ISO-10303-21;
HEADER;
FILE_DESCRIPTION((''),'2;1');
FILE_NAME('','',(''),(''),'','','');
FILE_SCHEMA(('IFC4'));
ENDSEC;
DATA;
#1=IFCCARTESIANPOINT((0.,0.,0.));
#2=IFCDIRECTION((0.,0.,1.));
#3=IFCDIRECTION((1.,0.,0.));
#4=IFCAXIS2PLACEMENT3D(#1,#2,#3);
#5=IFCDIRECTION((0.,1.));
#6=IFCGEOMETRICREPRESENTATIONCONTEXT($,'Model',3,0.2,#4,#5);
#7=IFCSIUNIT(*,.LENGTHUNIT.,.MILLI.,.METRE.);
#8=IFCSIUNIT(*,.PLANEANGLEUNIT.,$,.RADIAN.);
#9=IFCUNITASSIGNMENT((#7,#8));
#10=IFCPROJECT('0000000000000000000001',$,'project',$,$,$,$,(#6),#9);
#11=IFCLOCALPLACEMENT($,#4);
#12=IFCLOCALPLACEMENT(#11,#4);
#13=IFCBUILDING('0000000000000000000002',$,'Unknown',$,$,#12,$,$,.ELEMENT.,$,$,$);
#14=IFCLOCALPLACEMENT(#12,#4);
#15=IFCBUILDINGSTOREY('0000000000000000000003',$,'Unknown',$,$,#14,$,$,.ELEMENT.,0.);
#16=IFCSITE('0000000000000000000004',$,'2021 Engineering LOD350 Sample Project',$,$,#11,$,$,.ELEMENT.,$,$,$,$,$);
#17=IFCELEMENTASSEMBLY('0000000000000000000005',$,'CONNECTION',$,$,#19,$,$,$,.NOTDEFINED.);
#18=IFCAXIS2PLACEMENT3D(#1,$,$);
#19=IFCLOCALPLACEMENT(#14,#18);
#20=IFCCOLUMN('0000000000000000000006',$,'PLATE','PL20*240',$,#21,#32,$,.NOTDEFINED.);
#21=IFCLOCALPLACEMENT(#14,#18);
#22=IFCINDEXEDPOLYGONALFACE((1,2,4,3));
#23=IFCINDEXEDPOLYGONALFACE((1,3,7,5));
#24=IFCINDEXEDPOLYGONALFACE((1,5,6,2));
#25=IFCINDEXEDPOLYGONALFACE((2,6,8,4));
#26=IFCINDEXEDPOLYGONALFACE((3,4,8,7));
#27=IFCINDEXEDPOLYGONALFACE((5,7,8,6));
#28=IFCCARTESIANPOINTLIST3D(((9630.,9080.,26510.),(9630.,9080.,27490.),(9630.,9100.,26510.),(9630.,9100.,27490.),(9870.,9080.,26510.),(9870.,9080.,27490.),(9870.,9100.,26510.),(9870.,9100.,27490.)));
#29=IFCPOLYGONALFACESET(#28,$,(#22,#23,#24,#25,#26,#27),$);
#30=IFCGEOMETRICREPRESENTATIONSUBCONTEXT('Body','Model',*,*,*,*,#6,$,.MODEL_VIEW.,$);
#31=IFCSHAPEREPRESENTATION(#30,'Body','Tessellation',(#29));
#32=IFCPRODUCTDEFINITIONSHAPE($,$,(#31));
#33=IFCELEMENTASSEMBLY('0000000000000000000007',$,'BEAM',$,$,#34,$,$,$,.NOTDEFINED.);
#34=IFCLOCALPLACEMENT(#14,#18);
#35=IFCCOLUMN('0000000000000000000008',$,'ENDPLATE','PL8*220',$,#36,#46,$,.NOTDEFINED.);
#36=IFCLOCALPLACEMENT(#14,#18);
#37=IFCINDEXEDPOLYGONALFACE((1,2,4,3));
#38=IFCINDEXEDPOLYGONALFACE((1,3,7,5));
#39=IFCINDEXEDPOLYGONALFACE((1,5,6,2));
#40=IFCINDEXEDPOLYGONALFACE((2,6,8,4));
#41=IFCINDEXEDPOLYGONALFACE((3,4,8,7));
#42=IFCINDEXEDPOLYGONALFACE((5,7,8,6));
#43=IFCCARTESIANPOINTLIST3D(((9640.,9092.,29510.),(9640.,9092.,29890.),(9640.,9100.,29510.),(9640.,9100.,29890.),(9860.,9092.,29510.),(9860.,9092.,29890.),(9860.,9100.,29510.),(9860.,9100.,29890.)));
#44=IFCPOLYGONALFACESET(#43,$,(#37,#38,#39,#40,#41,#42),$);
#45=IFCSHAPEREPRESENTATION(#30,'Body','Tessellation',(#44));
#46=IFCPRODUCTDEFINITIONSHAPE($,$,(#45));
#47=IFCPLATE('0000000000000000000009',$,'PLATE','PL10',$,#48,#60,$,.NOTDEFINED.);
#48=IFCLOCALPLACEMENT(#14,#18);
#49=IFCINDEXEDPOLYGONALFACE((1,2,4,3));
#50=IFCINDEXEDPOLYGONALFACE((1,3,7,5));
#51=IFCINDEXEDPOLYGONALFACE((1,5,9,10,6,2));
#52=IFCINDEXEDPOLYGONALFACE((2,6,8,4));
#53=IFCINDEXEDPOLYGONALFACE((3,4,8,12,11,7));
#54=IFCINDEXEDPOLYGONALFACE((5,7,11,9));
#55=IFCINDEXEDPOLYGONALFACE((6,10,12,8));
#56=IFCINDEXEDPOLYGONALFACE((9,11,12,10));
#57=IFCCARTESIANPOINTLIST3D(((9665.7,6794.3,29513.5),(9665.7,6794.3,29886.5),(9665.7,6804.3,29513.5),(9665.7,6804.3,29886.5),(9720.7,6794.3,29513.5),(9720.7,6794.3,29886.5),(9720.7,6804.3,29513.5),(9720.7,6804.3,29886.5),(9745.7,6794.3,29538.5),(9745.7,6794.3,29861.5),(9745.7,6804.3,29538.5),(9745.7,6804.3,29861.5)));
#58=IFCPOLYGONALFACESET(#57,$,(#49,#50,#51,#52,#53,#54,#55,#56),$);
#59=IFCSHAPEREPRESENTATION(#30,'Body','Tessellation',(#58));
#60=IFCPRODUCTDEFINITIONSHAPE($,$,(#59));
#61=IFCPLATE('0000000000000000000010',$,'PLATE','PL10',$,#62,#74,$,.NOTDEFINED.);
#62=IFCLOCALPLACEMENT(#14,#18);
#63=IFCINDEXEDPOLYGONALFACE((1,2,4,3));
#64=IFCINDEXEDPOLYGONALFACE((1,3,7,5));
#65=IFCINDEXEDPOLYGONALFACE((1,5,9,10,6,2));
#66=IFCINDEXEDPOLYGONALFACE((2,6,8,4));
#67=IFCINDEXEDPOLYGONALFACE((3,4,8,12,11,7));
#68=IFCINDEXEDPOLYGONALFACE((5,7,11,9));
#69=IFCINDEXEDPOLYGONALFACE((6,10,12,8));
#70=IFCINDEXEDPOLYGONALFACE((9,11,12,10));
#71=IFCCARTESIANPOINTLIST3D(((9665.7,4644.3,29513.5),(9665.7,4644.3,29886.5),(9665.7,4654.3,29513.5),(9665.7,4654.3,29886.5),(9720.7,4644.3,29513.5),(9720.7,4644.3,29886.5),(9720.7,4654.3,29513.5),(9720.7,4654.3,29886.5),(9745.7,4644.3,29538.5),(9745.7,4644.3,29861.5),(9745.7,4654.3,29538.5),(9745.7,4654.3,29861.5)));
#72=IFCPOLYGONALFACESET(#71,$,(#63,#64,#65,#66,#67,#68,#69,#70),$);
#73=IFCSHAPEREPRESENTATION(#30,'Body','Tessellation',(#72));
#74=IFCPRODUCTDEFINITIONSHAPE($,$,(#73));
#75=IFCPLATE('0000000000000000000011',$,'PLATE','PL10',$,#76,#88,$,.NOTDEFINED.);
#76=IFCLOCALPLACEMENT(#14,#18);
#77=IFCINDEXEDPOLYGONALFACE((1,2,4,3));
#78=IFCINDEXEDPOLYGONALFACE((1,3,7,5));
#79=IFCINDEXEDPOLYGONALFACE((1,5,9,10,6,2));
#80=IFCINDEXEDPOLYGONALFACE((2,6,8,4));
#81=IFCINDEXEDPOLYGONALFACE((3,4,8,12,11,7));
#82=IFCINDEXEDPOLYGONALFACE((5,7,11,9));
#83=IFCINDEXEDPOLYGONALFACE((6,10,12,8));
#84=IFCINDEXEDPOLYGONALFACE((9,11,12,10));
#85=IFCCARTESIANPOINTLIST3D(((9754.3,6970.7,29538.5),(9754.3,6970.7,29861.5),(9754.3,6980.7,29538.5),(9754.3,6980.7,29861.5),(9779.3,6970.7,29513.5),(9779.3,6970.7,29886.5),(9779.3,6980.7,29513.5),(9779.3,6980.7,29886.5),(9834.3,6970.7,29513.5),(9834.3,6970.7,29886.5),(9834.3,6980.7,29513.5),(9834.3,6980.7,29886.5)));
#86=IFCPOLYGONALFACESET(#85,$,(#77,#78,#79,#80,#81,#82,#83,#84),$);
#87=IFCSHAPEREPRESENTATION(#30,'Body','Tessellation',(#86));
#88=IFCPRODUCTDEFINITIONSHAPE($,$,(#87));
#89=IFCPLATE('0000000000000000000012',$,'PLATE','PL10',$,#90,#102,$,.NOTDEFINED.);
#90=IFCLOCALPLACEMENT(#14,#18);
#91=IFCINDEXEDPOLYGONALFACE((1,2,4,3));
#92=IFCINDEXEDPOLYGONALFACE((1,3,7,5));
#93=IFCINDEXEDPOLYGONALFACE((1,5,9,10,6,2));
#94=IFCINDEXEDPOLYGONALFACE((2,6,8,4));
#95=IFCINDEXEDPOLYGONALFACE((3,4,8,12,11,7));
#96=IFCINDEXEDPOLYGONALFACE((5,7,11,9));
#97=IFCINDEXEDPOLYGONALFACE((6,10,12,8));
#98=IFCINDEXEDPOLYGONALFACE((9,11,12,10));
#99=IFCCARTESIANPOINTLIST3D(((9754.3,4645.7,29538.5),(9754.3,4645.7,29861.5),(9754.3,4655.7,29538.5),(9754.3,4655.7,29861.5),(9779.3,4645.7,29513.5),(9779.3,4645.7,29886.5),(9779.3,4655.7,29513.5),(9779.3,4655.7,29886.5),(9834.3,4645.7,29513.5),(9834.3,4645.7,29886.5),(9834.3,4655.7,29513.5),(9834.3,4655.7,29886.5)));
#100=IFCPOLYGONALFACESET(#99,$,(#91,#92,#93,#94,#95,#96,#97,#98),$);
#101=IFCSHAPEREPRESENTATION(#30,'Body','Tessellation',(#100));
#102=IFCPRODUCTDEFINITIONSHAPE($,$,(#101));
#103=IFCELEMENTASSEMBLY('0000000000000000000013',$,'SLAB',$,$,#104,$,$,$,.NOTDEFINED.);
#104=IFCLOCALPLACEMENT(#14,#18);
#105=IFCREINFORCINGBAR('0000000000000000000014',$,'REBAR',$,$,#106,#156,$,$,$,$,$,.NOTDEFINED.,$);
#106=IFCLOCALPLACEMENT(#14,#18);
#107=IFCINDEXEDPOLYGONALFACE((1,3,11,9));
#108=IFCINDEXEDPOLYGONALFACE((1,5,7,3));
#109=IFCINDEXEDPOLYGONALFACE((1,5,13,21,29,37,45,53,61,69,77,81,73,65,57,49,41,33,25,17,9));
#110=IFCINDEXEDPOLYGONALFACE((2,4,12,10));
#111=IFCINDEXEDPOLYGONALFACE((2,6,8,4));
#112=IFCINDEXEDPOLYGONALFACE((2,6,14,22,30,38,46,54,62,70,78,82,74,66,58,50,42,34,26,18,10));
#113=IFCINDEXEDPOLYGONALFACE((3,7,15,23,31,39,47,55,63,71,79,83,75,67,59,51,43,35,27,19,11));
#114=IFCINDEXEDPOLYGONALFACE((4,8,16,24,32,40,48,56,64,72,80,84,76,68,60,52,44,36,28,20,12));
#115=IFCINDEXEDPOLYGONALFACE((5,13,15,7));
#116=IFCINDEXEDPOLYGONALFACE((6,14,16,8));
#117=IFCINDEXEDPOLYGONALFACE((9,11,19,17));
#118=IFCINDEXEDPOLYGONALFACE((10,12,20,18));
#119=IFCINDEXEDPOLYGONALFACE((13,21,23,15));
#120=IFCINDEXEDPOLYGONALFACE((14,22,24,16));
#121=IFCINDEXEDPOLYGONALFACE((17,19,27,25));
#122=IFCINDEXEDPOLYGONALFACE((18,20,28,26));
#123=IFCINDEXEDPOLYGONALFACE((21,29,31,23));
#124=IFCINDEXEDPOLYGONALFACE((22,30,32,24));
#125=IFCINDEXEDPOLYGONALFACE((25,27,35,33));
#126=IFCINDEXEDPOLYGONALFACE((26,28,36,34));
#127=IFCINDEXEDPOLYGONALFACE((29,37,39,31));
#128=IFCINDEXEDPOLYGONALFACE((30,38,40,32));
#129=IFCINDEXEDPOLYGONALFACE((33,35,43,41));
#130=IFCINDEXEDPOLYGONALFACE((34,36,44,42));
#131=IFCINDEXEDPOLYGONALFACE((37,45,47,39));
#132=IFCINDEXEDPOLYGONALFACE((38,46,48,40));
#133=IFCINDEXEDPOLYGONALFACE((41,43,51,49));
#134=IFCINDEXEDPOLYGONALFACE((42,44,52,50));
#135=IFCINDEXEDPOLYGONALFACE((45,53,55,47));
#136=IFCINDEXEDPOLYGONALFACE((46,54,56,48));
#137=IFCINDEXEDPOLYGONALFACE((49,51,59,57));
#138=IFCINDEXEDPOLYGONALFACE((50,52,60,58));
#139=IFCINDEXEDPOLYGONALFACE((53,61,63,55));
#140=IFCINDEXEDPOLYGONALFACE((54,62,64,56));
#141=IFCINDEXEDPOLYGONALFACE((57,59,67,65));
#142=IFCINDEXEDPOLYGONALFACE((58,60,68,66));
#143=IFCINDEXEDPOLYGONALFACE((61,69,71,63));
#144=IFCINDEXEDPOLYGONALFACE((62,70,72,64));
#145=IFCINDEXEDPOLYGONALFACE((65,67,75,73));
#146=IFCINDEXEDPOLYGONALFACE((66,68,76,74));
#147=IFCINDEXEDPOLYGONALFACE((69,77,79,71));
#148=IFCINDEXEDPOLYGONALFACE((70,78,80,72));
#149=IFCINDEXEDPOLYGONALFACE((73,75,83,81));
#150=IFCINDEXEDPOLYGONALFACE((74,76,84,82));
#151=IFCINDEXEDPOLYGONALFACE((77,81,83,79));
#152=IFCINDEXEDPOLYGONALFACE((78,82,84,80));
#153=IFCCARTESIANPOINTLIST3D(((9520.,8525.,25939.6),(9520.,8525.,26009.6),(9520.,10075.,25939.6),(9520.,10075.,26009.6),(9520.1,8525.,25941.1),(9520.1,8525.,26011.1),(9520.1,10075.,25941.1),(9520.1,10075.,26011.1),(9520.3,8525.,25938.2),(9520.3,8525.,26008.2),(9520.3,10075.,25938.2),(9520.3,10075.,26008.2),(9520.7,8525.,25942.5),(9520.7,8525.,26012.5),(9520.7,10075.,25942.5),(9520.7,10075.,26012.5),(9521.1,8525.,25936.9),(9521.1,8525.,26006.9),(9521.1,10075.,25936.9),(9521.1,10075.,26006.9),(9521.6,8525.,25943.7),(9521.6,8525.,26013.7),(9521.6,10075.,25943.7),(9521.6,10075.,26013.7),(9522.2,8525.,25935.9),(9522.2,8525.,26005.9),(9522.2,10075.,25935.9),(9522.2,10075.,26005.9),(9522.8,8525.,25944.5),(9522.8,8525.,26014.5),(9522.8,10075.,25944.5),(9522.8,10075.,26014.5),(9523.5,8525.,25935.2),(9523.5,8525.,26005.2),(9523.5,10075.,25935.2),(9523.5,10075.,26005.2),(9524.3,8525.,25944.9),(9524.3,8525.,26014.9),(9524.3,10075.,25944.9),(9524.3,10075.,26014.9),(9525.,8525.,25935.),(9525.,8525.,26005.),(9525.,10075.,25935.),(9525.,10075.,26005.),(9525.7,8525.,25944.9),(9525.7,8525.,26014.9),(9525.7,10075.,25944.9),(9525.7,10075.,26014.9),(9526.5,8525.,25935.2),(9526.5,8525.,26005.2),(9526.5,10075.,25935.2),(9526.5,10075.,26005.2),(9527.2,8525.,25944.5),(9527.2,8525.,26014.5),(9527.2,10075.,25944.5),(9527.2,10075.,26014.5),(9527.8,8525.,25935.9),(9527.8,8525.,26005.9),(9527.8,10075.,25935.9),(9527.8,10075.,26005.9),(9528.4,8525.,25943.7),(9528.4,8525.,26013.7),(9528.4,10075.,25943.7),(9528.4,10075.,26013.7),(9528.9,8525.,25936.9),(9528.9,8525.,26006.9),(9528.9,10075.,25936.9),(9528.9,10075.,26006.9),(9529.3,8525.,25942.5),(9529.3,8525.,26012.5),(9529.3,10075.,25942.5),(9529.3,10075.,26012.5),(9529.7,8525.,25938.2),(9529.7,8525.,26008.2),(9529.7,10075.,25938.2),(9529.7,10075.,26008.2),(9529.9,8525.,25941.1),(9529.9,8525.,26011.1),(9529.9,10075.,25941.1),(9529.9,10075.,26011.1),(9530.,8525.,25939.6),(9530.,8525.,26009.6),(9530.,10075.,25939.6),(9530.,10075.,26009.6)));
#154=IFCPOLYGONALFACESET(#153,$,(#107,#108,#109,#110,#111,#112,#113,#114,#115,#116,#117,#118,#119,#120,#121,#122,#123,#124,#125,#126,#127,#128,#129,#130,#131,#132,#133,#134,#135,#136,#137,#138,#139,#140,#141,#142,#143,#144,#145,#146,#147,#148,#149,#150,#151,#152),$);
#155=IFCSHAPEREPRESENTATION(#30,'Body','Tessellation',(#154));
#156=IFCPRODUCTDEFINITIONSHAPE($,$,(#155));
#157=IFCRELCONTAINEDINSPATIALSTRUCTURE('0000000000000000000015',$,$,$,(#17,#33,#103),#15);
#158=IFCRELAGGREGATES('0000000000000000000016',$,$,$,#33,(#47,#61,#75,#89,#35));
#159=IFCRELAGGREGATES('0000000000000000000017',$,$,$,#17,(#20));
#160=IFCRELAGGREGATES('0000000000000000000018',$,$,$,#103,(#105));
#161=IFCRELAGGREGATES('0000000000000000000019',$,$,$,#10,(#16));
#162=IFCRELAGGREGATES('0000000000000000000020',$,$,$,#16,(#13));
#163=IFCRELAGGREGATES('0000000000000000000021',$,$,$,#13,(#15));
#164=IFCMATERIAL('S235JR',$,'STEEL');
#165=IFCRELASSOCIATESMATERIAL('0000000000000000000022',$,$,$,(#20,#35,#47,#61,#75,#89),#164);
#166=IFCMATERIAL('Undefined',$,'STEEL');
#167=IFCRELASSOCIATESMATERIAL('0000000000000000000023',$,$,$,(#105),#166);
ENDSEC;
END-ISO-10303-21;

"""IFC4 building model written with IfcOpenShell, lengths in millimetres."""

from ifc_helpers import new_model, entity, si_unit, direction, frame, origin_with_axes, place, context, subcontext, project, spatial, line, indexed_curve, outline, extrude, source, transform, mapped, material, element, aggregate, save


model = new_model("IFC4")

# Units and contexts
model_context = context("Model", 3, precision=0.2, world=origin_with_axes(), true_north=direction((0.0, 1.0)))
body_context = subcontext(model_context, "Body", "Model", "MODEL_VIEW")
ifc_project = project(units=[si_unit("LENGTHUNIT", "METRE", prefix="MILLI"), si_unit("PLANEANGLEUNIT", "RADIAN")], contexts=[model_context])

# Site, building, storey
site_placement = place(None, origin_with_axes())
site = spatial("IfcSite", under=ifc_project, at=site_placement, Name="2021 Engineering LOD350 Sample Project", CompositionType="ELEMENT")
building_placement = place(site_placement, origin_with_axes())
building = spatial("IfcBuilding", under=site, at=building_placement, Name="Unknown", CompositionType="ELEMENT")
storey_placement = place(building_placement, origin_with_axes())
storey = spatial("IfcBuildingStorey", under=building, at=storey_placement, Name="Unknown", CompositionType="ELEMENT", Elevation=0.0)

# Element assembly, column
assembly_1_placement = place(storey_placement, frame((9750.0, 9090.0, 26510.0), z_axis=(0.0, -1.0, 0.0), x_axis=(0.0, 0.0, 1.0)))
assembly_1 = element("IfcElementAssembly", 1, at=assembly_1_placement, inside=storey, Name="CONNECTION", PredefinedType="NOTDEFINED")
ifc_material_1 = material(Name="S235JR", Category="STEEL")
column_1_placement = place(assembly_1_placement, origin_with_axes())
column_1 = element("IfcColumn", 2, at=column_1_placement, material=ifc_material_1, Name="PLATE", Description="PL20*240", PredefinedType="NOTDEFINED", context=body_context, shape_type="SolidModel", body=[
    extrude(outline(indexed_curve([(-10.0, -120.0), (10.0, -120.0), (10.0, 120.0), (-10.0, 120.0)], segments=[line(1, 2, 3, 4, 1)])), frame((0.0, 0.0, 0.0), z_axis=(-1.0, 0.0, 0.0), x_axis=(0.0, 0.0, 1.0)), (0.0, 0.0, -1.0), 980.0),
])

# Element assembly, column, plates
assembly_2_placement = place(storey_placement, frame((9750.0, 0.0, 29700.0), z_axis=(1.0, 0.0, 0.0), x_axis=(0.0, 1.0, 0.0)))
assembly_2 = element("IfcElementAssembly", 3, at=assembly_2_placement, inside=storey, Name="BEAM", PredefinedType="NOTDEFINED")
column_2_placement = place(assembly_2_placement, frame((9096.0, -190.0, 0.0), z_axis=(-1.0, 0.0, 0.0), x_axis=(0.0, 1.0, 0.0)))
column_2 = element("IfcColumn", 4, at=column_2_placement, material=ifc_material_1, Name="ENDPLATE", Description="PL8*220", PredefinedType="NOTDEFINED", context=body_context, shape_type="SolidModel", body=[
    extrude(outline(indexed_curve([(-4.0, -110.0), (4.0, -110.0), (4.0, 110.0), (-4.0, 110.0)], segments=[line(1, 2, 3, 4, 1)])), frame((0.0, 0.0, 0.0), z_axis=(-1.0, 0.0, 0.0), x_axis=(0.0, 0.0, 1.0)), (0.0, 0.0, -1.0), 380.0),
])
plate_1_placement = place(assembly_2_placement, frame((6799.3, -186.5, -4.3), z_axis=(1.0, 0.0, 0.0), x_axis=(0.0, 0.0, -1.0)))
plate_1 = element("IfcPlate", 5, at=plate_1_placement, material=ifc_material_1, Name="PLATE", Description="PL10", PredefinedType="NOTDEFINED", context=body_context, shape_type="SolidModel", body=[
    extrude(outline(indexed_curve([(0.0, 25.0), (25.0, 0.0), (80.0, 0.0), (80.0, 373.0), (25.0, 373.0), (0.0, 348.0)], segments=[line(1, 2, 3, 4, 5, 6, 1)])), frame((0.0, 0.0, 5.0), z_axis=(0.0, 0.0, 1.0), x_axis=(1.0, 0.0, 0.0)), (0.0, 0.0, -1.0), 10.0),
])
plate_2_placement = place(assembly_2_placement, frame((4649.3, -186.5, -4.3), z_axis=(1.0, 0.0, 0.0), x_axis=(0.0, 0.0, -1.0)))
plate_2 = element("IfcPlate", 6, at=plate_2_placement, material=ifc_material_1, Name="PLATE", Description="PL10", PredefinedType="NOTDEFINED", context=body_context, shape_type="SolidModel", body=[
    extrude(outline(indexed_curve([(0.0, 25.0), (25.0, 0.0), (80.0, 0.0), (80.0, 373.0), (25.0, 373.0), (0.0, 348.0)], segments=[line(1, 2, 3, 4, 5, 6, 1)])), frame((0.0, 0.0, 5.0), z_axis=(0.0, 0.0, 1.0), x_axis=(1.0, 0.0, 0.0)), (0.0, 0.0, -1.0), 10.0),
])
plate_3_placement = place(assembly_2_placement, frame((6975.7, -186.5, 4.3), z_axis=(-1.0, 0.0, 0.0), x_axis=(0.0, 0.0, 1.0)))
plate_3 = element("IfcPlate", 7, at=plate_3_placement, material=ifc_material_1, Name="PLATE", Description="PL10", PredefinedType="NOTDEFINED", context=body_context, shape_type="SolidModel", body=[
    extrude(outline(indexed_curve([(0.0, 25.0), (25.0, 0.0), (80.0, 0.0), (80.0, 373.0), (25.0, 373.0), (0.0, 348.0)], segments=[line(1, 2, 3, 4, 5, 6, 1)])), frame((0.0, 0.0, 5.0), z_axis=(0.0, 0.0, 1.0), x_axis=(1.0, 0.0, 0.0)), (0.0, 0.0, -1.0), 10.0),
])
plate_4_placement = place(assembly_2_placement, frame((4650.7, -186.5, 4.3), z_axis=(-1.0, 0.0, 0.0), x_axis=(0.0, 0.0, 1.0)))
plate_4 = element("IfcPlate", 8, at=plate_4_placement, material=ifc_material_1, Name="PLATE", Description="PL10", PredefinedType="NOTDEFINED", context=body_context, shape_type="SolidModel", body=[
    extrude(outline(indexed_curve([(0.0, 25.0), (25.0, 0.0), (80.0, 0.0), (80.0, 373.0), (25.0, 373.0), (0.0, 348.0)], segments=[line(1, 2, 3, 4, 5, 6, 1)])), frame((0.0, 0.0, 5.0), z_axis=(0.0, 0.0, 1.0), x_axis=(1.0, 0.0, 0.0)), (0.0, 0.0, -1.0), 10.0),
])
aggregate(assembly_2, [plate_1, plate_2, plate_3, plate_4, column_2])

# Element assembly, reinforcing bar
assembly_3_placement = place(storey_placement, frame((0.0, 19194.4, 25975.0), z_axis=(0.0, 0.0, 1.0), x_axis=(0.0, -1.0, 0.0)))
assembly_3 = element("IfcElementAssembly", 9, at=assembly_3_placement, inside=storey, Name="SLAB", PredefinedType="NOTDEFINED")
ifc_material_2 = material(Name="Undefined", Category="STEEL")
shared_shape_1 = source(origin_with_axes(), body_context, "Body", "AdvancedSweptSolid", [
    entity("IfcSweptDiskSolid", entity("IfcIndexedPolyCurve", entity("IfcCartesianPointList3D", [[0.0, 0.0, 0.0], [1550.0, 0.0, 0.0]]), [entity("IfcLineIndex", [1, 2])]), 5.0),
])
reinforcing_bar_1_placement = place(assembly_3_placement, frame((10669.4, 9525.0, -35.0), z_axis=(0.0, 0.0, -1.0), x_axis=(-1.0, 0.0, 0.0)))
reinforcing_bar_1 = element("IfcReinforcingBar", 10, at=reinforcing_bar_1_placement, material=ifc_material_2, Name="REBAR", PredefinedType="NOTDEFINED", context=body_context, shape_type="MappedRepresentation", body=[
    mapped(shared_shape_1, transform((0.0, 0.0, 0.0))),
    mapped(shared_shape_1, transform((0.0, 0.0, -70.0))),
])

aggregate(assembly_1, [column_1])

aggregate(assembly_3, [reinforcing_bar_1])

save(model, "model.ifc")
